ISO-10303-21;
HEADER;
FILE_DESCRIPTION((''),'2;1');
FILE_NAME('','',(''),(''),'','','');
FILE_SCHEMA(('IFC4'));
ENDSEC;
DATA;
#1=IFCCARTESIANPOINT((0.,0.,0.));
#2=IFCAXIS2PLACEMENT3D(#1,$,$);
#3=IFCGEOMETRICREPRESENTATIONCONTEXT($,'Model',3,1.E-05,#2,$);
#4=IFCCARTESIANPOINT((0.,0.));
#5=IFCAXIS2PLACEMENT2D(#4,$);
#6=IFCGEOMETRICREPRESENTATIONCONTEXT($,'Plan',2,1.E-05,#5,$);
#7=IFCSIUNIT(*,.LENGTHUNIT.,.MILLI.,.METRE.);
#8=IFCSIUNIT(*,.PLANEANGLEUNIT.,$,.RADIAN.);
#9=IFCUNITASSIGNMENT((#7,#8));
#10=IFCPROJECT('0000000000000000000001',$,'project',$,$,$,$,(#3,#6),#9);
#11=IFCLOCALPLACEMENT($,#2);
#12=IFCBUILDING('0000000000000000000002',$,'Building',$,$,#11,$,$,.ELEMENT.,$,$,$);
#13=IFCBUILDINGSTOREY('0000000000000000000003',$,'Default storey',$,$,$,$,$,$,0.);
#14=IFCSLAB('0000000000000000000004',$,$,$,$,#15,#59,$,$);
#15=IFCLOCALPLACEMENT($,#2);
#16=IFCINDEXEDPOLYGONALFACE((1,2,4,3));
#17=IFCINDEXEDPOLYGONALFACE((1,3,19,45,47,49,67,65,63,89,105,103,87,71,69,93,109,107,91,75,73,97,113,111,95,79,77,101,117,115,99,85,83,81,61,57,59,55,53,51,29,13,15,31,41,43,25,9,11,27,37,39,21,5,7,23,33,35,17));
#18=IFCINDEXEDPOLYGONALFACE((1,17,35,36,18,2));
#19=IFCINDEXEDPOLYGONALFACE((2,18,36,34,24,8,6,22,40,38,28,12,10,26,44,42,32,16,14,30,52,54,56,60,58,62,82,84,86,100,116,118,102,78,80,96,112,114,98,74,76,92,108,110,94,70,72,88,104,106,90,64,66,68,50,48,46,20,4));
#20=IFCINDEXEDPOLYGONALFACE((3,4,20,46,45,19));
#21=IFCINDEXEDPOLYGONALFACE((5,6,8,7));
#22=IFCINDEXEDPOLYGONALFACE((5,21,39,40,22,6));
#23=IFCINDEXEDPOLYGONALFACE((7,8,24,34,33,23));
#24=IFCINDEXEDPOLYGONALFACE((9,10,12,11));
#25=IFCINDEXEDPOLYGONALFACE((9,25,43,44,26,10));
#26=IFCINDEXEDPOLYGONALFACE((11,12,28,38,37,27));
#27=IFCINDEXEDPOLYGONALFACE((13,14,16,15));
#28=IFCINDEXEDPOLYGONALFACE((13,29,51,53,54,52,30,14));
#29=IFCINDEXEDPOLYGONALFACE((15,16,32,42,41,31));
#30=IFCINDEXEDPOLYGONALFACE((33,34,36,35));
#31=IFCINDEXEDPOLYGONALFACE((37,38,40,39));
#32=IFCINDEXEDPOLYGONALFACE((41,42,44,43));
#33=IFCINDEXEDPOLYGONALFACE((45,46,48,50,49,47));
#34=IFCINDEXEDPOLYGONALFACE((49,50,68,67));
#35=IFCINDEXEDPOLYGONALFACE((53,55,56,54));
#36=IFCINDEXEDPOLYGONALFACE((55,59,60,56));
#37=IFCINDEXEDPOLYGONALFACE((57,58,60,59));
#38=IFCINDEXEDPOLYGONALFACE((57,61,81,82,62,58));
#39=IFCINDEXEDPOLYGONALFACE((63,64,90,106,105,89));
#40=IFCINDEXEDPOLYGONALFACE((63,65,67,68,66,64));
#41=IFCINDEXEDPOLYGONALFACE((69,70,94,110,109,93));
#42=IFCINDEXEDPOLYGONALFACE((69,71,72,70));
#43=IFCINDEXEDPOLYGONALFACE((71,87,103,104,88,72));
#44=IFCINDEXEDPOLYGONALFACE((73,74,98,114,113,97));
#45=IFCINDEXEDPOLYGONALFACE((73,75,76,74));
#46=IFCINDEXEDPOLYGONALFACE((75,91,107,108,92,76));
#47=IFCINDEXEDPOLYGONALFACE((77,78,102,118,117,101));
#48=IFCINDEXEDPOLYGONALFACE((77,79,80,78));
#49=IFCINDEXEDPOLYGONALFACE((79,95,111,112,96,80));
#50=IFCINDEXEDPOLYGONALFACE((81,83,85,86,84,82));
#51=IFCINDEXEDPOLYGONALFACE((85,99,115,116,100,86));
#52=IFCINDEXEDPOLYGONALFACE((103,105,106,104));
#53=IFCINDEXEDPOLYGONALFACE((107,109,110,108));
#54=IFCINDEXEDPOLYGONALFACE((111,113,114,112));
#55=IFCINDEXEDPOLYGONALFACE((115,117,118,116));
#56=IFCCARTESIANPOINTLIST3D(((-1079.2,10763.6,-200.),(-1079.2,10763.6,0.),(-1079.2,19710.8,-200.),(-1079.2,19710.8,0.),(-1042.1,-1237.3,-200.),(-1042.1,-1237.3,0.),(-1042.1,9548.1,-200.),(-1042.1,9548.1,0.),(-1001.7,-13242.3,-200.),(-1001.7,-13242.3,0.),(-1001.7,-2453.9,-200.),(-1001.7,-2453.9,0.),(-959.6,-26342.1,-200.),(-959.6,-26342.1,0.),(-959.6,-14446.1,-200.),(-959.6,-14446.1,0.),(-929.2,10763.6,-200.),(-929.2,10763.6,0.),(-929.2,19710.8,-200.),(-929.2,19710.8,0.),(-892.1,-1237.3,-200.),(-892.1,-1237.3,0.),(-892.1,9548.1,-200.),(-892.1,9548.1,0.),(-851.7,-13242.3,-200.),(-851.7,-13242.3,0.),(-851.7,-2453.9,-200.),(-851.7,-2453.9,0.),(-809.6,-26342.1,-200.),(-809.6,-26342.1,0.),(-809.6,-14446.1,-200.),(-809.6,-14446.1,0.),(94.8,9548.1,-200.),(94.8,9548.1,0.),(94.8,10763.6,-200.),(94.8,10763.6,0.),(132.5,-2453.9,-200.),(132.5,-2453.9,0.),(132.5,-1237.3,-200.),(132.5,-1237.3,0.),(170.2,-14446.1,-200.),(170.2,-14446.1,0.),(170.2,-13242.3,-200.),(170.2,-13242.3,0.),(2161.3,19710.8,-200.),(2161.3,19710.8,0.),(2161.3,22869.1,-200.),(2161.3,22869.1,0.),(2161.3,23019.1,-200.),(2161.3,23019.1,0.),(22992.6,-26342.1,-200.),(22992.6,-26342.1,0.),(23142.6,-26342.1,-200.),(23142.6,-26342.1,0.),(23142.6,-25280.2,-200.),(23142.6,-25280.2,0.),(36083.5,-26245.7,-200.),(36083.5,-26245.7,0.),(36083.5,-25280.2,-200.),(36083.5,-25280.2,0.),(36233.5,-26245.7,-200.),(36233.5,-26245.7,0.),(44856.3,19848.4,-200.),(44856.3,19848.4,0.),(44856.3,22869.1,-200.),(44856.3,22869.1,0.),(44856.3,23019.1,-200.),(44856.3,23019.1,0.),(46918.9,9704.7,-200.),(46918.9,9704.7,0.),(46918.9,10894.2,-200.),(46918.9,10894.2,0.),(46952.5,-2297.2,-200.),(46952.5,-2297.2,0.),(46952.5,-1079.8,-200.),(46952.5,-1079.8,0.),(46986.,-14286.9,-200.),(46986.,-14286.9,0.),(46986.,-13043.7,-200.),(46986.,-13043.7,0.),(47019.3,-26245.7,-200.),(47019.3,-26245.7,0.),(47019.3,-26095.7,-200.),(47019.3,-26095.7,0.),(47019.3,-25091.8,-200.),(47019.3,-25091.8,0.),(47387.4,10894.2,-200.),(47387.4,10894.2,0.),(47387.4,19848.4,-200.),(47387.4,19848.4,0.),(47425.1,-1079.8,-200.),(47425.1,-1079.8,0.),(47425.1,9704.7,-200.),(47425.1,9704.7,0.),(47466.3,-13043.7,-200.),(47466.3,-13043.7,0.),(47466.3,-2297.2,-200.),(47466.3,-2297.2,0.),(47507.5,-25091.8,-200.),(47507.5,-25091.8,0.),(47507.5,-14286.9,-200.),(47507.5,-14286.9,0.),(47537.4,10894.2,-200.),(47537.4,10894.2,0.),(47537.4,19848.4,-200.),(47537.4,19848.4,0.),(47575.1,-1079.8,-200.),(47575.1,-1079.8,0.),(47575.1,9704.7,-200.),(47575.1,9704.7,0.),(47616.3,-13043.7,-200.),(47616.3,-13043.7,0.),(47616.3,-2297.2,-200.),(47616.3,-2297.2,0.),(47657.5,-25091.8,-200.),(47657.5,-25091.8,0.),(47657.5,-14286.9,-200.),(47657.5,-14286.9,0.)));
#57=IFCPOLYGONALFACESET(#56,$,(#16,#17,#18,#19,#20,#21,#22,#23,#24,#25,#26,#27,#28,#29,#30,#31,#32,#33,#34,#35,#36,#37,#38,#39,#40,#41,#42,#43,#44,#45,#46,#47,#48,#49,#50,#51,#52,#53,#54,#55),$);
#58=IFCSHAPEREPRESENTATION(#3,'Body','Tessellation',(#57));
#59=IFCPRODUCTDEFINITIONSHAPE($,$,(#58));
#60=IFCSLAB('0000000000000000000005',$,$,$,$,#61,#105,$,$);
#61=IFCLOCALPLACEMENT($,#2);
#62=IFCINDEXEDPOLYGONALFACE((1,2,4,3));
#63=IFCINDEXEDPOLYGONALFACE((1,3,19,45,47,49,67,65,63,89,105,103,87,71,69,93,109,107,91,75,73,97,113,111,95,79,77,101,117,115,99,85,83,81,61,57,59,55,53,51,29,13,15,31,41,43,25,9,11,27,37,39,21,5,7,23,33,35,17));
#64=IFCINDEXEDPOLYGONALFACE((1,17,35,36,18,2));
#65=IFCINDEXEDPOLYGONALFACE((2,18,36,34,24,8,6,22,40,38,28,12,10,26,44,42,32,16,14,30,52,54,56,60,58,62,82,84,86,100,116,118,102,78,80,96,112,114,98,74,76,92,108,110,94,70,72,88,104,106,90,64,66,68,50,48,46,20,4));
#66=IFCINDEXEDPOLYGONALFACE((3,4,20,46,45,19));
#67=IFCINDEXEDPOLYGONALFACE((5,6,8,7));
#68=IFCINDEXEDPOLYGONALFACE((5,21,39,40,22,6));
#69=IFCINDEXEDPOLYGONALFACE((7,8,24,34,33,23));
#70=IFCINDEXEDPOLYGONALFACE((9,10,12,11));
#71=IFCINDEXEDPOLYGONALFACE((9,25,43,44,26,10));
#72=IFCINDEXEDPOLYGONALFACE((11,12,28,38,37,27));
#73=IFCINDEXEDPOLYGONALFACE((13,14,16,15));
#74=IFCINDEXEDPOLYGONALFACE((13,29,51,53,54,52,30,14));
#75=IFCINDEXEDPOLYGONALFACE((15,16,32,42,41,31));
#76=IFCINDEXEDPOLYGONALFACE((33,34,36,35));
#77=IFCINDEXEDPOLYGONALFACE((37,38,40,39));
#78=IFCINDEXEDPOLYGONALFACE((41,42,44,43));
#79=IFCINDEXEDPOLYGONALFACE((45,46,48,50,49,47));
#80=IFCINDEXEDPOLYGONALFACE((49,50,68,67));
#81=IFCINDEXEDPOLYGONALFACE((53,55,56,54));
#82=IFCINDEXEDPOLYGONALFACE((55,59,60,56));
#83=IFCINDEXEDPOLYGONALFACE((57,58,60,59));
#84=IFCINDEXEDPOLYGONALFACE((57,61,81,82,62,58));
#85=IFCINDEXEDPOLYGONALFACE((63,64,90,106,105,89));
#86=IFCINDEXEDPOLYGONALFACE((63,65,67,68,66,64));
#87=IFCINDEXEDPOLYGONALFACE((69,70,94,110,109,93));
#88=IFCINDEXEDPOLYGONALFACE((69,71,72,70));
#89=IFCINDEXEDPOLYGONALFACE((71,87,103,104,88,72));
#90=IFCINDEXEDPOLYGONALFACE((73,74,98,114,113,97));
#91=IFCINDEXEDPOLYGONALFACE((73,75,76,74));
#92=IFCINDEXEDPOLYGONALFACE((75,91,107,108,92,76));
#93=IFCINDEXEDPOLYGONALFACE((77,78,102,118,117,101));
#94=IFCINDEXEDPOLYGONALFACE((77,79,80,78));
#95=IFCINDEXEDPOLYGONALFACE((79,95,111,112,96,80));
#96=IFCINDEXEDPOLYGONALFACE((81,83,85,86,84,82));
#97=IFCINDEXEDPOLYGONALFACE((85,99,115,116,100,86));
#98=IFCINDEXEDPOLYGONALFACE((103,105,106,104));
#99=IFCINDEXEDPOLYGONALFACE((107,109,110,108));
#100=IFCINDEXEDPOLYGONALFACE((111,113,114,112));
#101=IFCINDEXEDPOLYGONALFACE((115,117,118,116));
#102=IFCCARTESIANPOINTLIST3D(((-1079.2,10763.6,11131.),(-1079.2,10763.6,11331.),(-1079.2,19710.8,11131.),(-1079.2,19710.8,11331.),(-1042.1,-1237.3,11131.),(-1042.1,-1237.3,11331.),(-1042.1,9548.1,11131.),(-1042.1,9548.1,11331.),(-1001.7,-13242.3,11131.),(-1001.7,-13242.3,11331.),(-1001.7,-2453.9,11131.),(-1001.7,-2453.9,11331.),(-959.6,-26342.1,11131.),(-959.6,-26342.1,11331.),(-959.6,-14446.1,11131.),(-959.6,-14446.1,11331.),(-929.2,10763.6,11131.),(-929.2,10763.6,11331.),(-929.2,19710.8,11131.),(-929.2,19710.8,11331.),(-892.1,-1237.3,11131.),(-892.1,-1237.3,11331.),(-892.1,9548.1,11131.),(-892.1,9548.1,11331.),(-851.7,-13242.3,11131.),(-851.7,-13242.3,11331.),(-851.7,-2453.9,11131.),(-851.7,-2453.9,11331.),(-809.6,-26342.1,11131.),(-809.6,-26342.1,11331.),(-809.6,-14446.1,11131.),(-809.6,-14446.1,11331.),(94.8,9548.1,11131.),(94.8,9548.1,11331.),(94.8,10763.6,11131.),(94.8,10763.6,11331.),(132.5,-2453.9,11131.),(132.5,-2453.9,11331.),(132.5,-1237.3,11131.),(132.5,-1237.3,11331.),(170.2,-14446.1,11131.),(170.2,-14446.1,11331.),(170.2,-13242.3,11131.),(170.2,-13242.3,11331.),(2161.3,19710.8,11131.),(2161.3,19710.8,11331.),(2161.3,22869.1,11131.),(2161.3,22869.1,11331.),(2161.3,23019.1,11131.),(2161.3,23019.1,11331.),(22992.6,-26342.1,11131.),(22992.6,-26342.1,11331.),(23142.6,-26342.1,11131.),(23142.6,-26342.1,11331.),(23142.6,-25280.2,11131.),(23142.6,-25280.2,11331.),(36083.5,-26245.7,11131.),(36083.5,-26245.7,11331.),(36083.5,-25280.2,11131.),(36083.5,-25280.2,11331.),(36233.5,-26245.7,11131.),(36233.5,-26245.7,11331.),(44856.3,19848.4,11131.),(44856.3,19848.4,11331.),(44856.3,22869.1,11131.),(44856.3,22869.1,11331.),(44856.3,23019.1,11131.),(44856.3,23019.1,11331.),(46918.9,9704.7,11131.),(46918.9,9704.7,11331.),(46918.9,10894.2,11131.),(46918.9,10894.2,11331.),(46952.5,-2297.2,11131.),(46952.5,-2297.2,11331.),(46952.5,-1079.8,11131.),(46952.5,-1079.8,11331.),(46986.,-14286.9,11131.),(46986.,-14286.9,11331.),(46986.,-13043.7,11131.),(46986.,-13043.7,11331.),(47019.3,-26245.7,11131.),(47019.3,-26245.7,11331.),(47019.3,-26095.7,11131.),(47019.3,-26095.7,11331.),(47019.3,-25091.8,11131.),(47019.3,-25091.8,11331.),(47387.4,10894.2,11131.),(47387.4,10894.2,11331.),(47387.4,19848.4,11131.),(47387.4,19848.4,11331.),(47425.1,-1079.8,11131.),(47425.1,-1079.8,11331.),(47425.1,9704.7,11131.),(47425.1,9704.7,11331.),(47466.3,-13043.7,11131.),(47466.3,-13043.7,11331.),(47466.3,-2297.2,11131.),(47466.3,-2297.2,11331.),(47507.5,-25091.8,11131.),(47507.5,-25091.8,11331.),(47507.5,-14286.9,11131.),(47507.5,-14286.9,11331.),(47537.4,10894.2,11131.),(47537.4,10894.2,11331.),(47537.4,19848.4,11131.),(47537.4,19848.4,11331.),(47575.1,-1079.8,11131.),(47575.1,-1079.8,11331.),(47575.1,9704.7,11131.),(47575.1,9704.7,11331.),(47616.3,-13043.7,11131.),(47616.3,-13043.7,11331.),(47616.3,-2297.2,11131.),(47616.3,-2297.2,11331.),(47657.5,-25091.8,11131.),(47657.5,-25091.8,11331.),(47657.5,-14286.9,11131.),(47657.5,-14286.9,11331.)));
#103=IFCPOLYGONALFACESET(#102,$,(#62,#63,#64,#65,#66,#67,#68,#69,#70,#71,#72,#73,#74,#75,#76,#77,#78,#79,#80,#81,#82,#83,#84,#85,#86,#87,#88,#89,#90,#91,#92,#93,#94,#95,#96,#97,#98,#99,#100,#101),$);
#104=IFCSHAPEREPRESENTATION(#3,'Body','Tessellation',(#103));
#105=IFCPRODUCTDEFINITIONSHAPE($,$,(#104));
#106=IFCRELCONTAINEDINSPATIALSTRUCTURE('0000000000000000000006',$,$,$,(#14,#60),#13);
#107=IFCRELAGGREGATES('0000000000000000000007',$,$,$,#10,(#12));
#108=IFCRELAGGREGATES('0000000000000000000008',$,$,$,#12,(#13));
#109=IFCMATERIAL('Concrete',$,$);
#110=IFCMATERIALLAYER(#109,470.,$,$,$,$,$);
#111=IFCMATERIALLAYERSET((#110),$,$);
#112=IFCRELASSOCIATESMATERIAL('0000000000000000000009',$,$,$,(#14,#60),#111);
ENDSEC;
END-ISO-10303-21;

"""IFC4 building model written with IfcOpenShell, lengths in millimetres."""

from ifc_helpers import new_model, si_unit, frame, origin, origin_2d, place, context, project, spatial, polyline, outline, extrude, material, layer, layer_set, layer_usage, element, save


model = new_model("IFC4")

# Units and contexts
model_context = context("Model", 3, precision=1e-05, world=origin())
plan_context = context("Plan", 2, precision=1e-05, world=origin_2d())
ifc_project = project(units=[si_unit("LENGTHUNIT", "METRE", prefix="MILLI"), si_unit("PLANEANGLEUNIT", "RADIAN")], contexts=[model_context, plan_context])

# Building, storey
placement = place(None, origin())
building = spatial("IfcBuilding", under=ifc_project, at=placement, Name="Building", CompositionType="ELEMENT")
storey = spatial("IfcBuildingStorey", under=building, Name="Default storey", Elevation=0.0)

# Slabs
ifc_material_1 = material(Name="Concrete")
ifc_layer_1 = layer(ifc_material_1, 470.0)
ifc_layer_set_1 = layer_set([ifc_layer_1])
ifc_layer_usage_1 = layer_usage(ifc_layer_set_1, "AXIS3", "POSITIVE", 0.0)
element("IfcSlab", 1, at=placement, inside=storey, material=ifc_layer_usage_1, context=model_context, shape_type="SweptSolid", body=[
    extrude(outline(polyline([(46986.0, -14286.9), (46986.0, -13043.7), (47466.3, -13043.7), (47616.3, -13043.7), (47616.3, -2297.2), (47466.3, -2297.2), (46952.5, -2297.2), (46952.5, -1079.8), (47425.1, -1079.8), (47575.1, -1079.8), (47575.1, 9704.7), (47425.1, 9704.7), (46918.9, 9704.7), (46918.9, 10894.2), (47387.4, 10894.2), (47537.4, 10894.2), (47537.4, 19848.4), (47387.4, 19848.4), (44856.3, 19848.4), (44856.3, 22869.1), (44856.3, 23019.1), (2161.3, 23019.1), (2161.3, 22869.1), (2161.3, 19710.8), (-929.2, 19710.8), (-1079.2, 19710.8), (-1079.2, 10763.6), (-929.2, 10763.6), (94.8, 10763.6), (94.8, 9548.1), (-892.1, 9548.1), (-1042.1, 9548.1), (-1042.1, -1237.3), (-892.1, -1237.3), (132.5, -1237.3), (132.5, -2453.9), (-851.7, -2453.9), (-1001.7, -2453.9), (-1001.7, -13242.3), (-851.7, -13242.3), (170.2, -13242.3), (170.2, -14446.1), (-809.6, -14446.1), (-959.6, -14446.1), (-959.6, -26342.1), (-809.6, -26342.1), (22992.6, -26342.1), (23142.6, -26342.1), (23142.6, -25280.2), (36083.5, -25280.2), (36083.5, -26245.7), (36233.5, -26245.7), (47019.3, -26245.7), (47019.3, -26095.7), (47019.3, -25091.8), (47507.5, -25091.8), (47657.5, -25091.8), (47657.5, -14286.9), (47507.5, -14286.9), (46986.0, -14286.9)])), frame((0.0, 0.0, -200.0), z_axis=(0.0, 0.0, 1000.0), x_axis=(1000.0, 0.0, 0.0)), (0.0, 0.0, 1.0), 200.0),
])
element("IfcSlab", 2, at=placement, inside=storey, material=ifc_layer_usage_1, context=model_context, shape_type="SweptSolid", body=[
    extrude(outline(polyline([(46986.0, -14286.9), (46986.0, -13043.7), (47466.3, -13043.7), (47616.3, -13043.7), (47616.3, -2297.2), (47466.3, -2297.2), (46952.5, -2297.2), (46952.5, -1079.8), (47425.1, -1079.8), (47575.1, -1079.8), (47575.1, 9704.7), (47425.1, 9704.7), (46918.9, 9704.7), (46918.9, 10894.2), (47387.4, 10894.2), (47537.4, 10894.2), (47537.4, 19848.4), (47387.4, 19848.4), (44856.3, 19848.4), (44856.3, 22869.1), (44856.3, 23019.1), (2161.3, 23019.1), (2161.3, 22869.1), (2161.3, 19710.8), (-929.2, 19710.8), (-1079.2, 19710.8), (-1079.2, 10763.6), (-929.2, 10763.6), (94.8, 10763.6), (94.8, 9548.1), (-892.1, 9548.1), (-1042.1, 9548.1), (-1042.1, -1237.3), (-892.1, -1237.3), (132.5, -1237.3), (132.5, -2453.9), (-851.7, -2453.9), (-1001.7, -2453.9), (-1001.7, -13242.3), (-851.7, -13242.3), (170.2, -13242.3), (170.2, -14446.1), (-809.6, -14446.1), (-959.6, -14446.1), (-959.6, -26342.1), (-809.6, -26342.1), (22992.6, -26342.1), (23142.6, -26342.1), (23142.6, -25280.2), (36083.5, -25280.2), (36083.5, -26245.7), (36233.5, -26245.7), (47019.3, -26245.7), (47019.3, -26095.7), (47019.3, -25091.8), (47507.5, -25091.8), (47657.5, -25091.8), (47657.5, -14286.9), (47507.5, -14286.9), (46986.0, -14286.9)])), frame((0.0, 0.0, 11331.0), z_axis=(0.0, 0.0, 1000.0), x_axis=(1000.0, 0.0, 0.0)), (0.0, 0.0, -1.0), 200.0),
])

save(model, "model.ifc")
